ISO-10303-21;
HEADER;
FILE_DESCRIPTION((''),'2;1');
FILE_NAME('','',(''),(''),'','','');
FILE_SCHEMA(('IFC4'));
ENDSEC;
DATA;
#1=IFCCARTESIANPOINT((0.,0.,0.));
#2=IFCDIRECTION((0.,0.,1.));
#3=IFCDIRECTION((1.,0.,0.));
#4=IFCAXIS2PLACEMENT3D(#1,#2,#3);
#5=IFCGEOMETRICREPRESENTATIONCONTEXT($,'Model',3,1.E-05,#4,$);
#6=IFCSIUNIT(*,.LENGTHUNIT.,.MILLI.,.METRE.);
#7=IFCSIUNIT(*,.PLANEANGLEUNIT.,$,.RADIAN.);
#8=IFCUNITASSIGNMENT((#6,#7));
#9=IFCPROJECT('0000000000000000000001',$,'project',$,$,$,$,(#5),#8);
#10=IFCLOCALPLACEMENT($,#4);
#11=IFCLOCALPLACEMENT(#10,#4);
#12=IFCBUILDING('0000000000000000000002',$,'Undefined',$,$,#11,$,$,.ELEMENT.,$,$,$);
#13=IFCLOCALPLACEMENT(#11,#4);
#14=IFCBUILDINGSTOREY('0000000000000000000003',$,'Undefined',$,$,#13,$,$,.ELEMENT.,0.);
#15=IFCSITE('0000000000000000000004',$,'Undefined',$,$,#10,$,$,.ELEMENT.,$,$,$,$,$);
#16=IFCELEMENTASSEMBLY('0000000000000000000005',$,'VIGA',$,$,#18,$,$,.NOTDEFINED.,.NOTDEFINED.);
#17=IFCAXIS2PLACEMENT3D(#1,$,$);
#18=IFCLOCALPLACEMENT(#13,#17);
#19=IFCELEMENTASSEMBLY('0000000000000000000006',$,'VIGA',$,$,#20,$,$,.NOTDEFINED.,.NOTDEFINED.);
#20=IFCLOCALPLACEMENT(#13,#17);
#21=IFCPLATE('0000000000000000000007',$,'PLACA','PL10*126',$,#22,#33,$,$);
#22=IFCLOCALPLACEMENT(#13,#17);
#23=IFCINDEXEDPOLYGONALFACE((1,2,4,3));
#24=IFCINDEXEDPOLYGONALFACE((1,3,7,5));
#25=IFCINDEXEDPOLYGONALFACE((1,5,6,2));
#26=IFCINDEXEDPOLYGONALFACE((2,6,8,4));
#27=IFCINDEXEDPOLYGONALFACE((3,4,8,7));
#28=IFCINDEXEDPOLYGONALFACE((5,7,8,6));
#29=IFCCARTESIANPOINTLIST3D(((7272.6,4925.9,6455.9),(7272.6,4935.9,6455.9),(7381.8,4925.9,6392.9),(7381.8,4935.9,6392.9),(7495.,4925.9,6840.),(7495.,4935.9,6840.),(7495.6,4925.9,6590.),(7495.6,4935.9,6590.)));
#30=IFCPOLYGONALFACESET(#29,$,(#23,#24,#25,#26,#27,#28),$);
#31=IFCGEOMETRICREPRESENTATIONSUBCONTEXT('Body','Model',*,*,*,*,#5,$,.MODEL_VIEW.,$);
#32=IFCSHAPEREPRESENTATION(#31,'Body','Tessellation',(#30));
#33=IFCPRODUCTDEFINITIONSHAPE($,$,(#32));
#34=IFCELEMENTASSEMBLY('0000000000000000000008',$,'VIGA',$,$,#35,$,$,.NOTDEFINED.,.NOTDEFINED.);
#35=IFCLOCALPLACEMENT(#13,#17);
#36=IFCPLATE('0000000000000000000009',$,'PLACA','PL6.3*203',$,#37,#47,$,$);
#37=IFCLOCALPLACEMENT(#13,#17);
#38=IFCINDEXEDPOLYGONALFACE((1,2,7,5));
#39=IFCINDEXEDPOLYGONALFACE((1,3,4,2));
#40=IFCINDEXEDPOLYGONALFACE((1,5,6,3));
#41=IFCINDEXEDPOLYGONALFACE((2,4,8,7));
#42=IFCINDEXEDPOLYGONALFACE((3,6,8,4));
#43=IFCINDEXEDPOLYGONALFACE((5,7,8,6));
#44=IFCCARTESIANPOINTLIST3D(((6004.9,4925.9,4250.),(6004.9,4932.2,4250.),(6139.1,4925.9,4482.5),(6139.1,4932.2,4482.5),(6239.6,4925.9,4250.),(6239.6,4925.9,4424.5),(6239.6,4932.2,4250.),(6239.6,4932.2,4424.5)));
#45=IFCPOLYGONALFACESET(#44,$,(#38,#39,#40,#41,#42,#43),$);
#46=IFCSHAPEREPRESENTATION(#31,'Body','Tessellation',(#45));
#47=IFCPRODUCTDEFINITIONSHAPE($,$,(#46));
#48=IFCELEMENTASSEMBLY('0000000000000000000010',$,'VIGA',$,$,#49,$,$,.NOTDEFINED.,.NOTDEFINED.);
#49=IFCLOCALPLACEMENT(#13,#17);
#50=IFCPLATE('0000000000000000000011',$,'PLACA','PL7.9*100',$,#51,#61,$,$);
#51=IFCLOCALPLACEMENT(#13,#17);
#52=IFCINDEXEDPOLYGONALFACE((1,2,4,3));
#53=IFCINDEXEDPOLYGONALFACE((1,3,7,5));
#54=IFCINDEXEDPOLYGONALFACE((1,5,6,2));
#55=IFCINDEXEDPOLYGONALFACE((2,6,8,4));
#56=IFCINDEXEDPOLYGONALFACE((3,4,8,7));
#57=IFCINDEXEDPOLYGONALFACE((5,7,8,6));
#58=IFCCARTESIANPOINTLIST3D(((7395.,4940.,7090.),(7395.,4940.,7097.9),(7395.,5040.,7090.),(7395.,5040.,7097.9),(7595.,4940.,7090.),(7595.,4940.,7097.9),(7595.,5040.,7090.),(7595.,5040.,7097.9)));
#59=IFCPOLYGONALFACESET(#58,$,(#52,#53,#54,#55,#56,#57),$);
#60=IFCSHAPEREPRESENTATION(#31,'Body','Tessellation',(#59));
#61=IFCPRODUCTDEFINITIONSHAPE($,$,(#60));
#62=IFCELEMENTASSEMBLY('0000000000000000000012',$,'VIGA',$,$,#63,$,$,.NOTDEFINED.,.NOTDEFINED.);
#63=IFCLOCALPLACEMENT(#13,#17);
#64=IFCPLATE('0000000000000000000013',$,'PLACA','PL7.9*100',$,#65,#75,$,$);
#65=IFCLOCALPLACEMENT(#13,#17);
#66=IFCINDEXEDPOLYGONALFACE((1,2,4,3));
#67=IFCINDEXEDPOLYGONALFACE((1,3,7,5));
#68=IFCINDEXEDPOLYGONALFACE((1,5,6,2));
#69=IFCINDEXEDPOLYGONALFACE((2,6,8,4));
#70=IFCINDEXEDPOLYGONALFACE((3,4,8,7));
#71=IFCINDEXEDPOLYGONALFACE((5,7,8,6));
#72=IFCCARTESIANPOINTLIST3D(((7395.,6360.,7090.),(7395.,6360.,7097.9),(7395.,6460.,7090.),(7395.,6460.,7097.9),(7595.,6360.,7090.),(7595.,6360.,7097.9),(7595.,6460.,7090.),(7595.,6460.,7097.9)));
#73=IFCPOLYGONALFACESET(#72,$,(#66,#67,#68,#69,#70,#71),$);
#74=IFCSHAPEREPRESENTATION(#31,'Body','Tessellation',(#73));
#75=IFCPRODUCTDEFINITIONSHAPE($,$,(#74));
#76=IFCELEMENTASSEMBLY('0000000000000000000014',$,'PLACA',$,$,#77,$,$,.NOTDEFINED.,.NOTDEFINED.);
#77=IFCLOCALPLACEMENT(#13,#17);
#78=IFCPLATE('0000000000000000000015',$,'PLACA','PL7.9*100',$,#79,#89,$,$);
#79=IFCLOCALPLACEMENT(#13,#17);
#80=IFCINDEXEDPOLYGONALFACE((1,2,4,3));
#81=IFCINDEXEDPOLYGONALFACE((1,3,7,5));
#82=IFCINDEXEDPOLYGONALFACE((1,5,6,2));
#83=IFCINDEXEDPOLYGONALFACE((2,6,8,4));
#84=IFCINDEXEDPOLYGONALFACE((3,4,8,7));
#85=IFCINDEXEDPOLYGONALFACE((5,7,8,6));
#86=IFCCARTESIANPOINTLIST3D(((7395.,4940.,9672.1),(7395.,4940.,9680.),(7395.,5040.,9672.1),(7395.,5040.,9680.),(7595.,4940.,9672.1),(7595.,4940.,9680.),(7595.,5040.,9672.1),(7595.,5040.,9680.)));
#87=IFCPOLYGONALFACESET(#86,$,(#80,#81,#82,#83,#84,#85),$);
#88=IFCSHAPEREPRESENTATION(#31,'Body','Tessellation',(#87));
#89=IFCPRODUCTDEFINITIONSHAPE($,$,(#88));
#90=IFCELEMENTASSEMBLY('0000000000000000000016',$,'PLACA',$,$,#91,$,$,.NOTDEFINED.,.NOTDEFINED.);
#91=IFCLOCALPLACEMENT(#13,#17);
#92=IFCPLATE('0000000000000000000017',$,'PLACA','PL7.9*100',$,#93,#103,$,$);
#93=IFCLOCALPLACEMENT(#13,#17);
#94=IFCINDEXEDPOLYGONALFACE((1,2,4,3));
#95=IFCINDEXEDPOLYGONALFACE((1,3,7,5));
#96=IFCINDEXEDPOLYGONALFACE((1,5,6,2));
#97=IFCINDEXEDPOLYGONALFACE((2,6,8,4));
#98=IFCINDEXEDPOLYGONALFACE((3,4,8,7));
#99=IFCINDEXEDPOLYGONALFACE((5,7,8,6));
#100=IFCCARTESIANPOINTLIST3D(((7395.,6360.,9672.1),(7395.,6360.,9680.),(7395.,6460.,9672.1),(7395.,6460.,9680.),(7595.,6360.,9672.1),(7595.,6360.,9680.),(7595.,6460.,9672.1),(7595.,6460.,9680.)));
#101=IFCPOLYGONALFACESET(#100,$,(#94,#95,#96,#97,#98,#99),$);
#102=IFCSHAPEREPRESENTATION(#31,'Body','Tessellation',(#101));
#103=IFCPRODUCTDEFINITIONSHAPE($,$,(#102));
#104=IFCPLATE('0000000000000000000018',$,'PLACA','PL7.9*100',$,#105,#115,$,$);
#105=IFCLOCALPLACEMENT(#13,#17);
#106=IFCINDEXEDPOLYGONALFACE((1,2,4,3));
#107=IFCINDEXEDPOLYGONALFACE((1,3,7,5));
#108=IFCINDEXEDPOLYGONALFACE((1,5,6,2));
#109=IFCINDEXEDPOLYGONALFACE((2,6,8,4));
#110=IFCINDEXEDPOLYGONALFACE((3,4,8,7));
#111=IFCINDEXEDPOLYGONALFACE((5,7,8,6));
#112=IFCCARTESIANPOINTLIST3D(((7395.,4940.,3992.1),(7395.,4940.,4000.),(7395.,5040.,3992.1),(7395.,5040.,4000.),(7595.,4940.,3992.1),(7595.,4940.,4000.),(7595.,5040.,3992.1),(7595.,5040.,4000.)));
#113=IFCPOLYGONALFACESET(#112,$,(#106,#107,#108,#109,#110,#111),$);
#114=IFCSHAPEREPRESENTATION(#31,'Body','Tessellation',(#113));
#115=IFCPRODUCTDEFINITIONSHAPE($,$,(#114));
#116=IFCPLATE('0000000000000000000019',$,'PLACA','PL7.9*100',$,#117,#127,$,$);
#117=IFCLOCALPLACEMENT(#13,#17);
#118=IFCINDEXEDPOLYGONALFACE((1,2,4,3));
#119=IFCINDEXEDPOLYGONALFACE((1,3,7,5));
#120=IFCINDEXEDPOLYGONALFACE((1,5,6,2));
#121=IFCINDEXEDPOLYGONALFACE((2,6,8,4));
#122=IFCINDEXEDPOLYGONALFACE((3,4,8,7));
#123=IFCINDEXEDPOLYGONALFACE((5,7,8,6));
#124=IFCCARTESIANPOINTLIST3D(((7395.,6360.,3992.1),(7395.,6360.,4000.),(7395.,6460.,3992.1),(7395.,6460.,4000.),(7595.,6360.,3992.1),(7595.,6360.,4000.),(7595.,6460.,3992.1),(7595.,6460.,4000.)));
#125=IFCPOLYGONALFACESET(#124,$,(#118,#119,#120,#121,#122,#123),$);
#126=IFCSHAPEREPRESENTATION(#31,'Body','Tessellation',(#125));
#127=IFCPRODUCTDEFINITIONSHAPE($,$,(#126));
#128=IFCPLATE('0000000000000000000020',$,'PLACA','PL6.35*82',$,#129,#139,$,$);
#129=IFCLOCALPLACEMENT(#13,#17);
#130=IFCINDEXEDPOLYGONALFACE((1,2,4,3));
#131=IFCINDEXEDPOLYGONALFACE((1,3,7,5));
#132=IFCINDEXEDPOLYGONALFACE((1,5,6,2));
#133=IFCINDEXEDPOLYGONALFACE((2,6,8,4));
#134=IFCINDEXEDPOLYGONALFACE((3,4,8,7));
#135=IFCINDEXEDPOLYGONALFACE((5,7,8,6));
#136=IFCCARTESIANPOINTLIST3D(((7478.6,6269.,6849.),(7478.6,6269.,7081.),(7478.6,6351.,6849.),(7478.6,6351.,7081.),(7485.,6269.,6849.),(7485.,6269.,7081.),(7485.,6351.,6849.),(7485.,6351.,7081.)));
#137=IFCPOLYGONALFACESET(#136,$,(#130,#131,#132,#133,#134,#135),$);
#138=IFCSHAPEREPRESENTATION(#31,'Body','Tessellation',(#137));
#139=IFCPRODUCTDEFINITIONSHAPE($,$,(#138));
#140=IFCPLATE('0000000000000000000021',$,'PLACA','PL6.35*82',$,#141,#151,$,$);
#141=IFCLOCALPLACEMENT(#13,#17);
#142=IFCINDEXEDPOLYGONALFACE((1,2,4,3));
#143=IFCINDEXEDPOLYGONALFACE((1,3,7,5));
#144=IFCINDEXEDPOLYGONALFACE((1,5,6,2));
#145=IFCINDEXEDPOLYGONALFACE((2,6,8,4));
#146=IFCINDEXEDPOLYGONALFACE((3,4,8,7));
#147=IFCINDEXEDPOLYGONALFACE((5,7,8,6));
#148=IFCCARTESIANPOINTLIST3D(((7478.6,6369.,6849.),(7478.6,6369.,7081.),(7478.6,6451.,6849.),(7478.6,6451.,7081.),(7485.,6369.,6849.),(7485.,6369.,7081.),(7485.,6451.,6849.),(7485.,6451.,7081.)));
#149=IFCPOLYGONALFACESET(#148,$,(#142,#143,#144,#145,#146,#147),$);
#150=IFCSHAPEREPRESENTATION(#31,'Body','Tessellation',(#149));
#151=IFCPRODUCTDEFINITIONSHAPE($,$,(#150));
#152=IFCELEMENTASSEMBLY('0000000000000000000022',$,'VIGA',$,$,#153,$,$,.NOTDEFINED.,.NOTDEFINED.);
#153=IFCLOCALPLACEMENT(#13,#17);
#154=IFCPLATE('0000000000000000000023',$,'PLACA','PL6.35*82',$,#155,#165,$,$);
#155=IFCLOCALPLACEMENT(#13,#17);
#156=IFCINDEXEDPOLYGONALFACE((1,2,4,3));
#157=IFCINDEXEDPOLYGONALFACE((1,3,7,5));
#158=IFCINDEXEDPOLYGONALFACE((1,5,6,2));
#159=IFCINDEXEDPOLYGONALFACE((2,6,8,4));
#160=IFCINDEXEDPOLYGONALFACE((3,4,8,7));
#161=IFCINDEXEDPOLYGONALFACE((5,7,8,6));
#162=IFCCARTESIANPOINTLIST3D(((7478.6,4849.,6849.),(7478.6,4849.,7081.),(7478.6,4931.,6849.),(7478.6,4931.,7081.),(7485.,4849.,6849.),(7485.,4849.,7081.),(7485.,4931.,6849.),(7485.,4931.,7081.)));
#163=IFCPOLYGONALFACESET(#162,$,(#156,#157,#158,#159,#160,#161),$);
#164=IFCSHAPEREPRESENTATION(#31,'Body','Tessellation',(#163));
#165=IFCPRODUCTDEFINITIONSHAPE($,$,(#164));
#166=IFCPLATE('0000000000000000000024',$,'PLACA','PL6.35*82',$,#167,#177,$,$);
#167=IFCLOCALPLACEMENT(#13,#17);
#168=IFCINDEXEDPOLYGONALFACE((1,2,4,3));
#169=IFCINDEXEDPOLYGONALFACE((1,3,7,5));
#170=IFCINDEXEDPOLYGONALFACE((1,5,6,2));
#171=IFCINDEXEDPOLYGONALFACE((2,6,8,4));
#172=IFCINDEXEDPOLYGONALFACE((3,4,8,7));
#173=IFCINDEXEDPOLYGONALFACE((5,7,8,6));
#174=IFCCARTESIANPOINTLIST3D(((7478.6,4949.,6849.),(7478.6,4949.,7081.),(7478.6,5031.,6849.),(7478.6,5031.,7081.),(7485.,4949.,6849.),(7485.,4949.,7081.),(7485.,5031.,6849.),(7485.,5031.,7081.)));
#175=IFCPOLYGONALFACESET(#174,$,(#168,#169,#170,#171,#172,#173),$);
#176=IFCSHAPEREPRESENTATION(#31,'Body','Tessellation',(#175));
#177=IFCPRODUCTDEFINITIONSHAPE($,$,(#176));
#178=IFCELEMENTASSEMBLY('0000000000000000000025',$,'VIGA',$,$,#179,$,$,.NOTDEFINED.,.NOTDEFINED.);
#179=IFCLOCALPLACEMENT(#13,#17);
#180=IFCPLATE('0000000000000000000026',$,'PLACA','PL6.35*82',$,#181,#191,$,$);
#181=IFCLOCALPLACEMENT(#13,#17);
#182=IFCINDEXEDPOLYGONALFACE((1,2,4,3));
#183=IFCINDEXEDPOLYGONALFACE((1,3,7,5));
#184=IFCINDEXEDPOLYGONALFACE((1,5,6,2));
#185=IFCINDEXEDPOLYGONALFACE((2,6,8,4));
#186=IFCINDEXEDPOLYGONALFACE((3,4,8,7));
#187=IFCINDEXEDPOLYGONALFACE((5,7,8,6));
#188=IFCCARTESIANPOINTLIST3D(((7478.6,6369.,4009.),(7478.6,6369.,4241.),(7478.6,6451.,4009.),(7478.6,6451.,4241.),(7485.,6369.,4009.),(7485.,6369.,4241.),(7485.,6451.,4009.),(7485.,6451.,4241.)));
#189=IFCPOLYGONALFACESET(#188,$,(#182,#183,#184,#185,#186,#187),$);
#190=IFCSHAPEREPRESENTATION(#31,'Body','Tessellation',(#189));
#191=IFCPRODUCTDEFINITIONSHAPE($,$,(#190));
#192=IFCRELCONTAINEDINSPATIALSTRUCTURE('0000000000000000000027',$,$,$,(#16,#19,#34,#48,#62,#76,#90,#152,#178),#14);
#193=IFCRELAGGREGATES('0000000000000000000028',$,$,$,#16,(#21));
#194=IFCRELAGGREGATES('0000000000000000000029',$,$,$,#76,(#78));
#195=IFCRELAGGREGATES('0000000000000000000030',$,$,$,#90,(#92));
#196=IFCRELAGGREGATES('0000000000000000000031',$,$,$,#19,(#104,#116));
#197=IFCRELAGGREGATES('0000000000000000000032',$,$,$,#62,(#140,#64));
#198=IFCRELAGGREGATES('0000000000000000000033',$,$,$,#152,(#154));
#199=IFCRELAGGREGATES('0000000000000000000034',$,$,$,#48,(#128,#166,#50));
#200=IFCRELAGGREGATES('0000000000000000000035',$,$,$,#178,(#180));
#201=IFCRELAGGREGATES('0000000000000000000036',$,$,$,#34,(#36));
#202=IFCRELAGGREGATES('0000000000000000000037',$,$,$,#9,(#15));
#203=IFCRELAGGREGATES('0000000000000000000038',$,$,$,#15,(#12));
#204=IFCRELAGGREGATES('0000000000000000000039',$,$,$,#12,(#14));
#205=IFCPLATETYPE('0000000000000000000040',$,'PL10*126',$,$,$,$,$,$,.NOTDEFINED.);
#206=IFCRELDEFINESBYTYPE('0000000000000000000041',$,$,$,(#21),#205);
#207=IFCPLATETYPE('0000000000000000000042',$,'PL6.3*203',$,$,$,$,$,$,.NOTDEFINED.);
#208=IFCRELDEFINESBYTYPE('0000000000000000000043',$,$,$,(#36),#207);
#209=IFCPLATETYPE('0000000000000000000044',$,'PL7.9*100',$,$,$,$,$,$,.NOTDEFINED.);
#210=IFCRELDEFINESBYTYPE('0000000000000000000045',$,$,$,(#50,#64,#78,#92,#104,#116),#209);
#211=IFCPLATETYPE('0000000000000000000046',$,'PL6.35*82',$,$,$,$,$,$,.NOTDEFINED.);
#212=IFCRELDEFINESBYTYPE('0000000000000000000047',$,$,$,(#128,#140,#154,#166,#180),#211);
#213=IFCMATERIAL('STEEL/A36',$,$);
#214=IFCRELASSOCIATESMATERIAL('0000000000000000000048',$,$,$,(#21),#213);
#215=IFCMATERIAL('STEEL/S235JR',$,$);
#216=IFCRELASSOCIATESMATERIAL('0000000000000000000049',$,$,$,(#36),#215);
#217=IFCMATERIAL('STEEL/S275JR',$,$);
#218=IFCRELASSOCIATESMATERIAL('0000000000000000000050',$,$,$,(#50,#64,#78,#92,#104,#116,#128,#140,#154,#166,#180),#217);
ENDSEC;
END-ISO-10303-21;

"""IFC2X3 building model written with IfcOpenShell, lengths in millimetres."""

from ifc_helpers import new_model, si_unit, frame, origin_with_axes, place, context, subcontext, project, spatial, polyline, outline, extrude, material, type_object, element, aggregate, save


model = new_model("IFC2X3")

# Units and contexts
model_context = context("Model", 3, precision=1e-05, world=origin_with_axes())
body_context = subcontext(model_context, "Body", "Model", "MODEL_VIEW")
ifc_project = project(units=[si_unit("LENGTHUNIT", "METRE", prefix="MILLI"), si_unit("PLANEANGLEUNIT", "RADIAN")], contexts=[model_context])

# Site, building, storey
site_placement = place(None, origin_with_axes())
site = spatial("IfcSite", under=ifc_project, at=site_placement, Name="Undefined", CompositionType="ELEMENT")
building_placement = place(site_placement, origin_with_axes())
building = spatial("IfcBuilding", under=site, at=building_placement, Name="Undefined", CompositionType="ELEMENT")
storey_placement = place(building_placement, origin_with_axes())
storey = spatial("IfcBuildingStorey", under=building, at=storey_placement, Name="Undefined", CompositionType="ELEMENT", Elevation=0.0)

# Element assemblies
ifc_material_1 = material(Name="STEEL/S275JR")
assembly_1_placement = place(storey_placement, origin_with_axes())
assembly_1 = element("IfcElementAssembly", 1, at=assembly_1_placement, inside=storey, Name="VIGA", AssemblyPlace="NOTDEFINED", PredefinedType="NOTDEFINED")
assembly_2_placement = place(storey_placement, origin_with_axes())
assembly_2 = element("IfcElementAssembly", 2, at=assembly_2_placement, inside=storey, Name="VIGA", AssemblyPlace="NOTDEFINED", PredefinedType="NOTDEFINED")

# Shared definitions
ifc_material_2 = material(Name="STEEL/S235JR")

# Plate
ifc_material_3 = material(Name="STEEL/A36")
plate_type_1 = type_object("IfcPlateType", Name="PL10*126", PredefinedType="NOTDEFINED")
plate_1_placement = place(assembly_1_placement, frame((7495.0, 4930.9, 6840.0), z_axis=(0.0, -1.0, 0.0), x_axis=(-0.500975, 0.0, -0.865462)))
plate_1 = element("IfcPlate", 3, at=plate_1_placement, type_object=plate_type_1, material=ifc_material_3, Name="PLACA", Description="PL10*126", context=body_context, shape_type="SweptSolid", body=[
    extrude(outline(polyline([(0.0, 0.0), (443.9, 0.0), (443.7, 126.0), (216.1, 125.7), (0.0, 0.0)])), frame((0.0, 0.0, -5.0), z_axis=(0.0, 0.0, 1.0), x_axis=(1.0, 0.0, 0.0)), (0.0, 0.0, 1.0), 10.0),
])
aggregate(assembly_1, [plate_1])

# Element assemblies, plates
assembly_3_placement = place(storey_placement, origin_with_axes())
assembly_3 = element("IfcElementAssembly", 4, at=assembly_3_placement, inside=storey, Name="VIGA", AssemblyPlace="NOTDEFINED", PredefinedType="NOTDEFINED")
plate_type_2 = type_object("IfcPlateType", Name="PL6.3*203", PredefinedType="NOTDEFINED")
plate_2_placement = place(assembly_3_placement, frame((6239.6, 4929.0, 4250.0), z_axis=(0.0, 1.0, 0.0), x_axis=(-1.0, 0.0, 0.0)))
plate_2 = element("IfcPlate", 5, at=plate_2_placement, type_object=plate_type_2, material=ifc_material_2, Name="PLACA", Description="PL6.3*203", context=body_context, shape_type="SweptSolid", body=[
    extrude(outline(polyline([(0.0, 0.0), (234.7, 0.0), (100.5, 232.5), (0.0, 174.5), (0.0, 0.0)])), frame((0.0, 0.0, -3.1), z_axis=(0.0, 0.0, 1.0), x_axis=(1.0, 0.0, 0.0)), (0.0, 0.0, 1.0), 6.3),
])
assembly_4_placement = place(storey_placement, origin_with_axes())
assembly_4 = element("IfcElementAssembly", 6, at=assembly_4_placement, inside=storey, Name="VIGA", AssemblyPlace="NOTDEFINED", PredefinedType="NOTDEFINED")
plate_type_3 = type_object("IfcPlateType", Name="PL7.9*100", PredefinedType="NOTDEFINED")
plate_3_placement = place(assembly_4_placement, frame((7395.0, 5040.0, 7093.9), z_axis=(0.0, 0.0, 1.0), x_axis=(0.0, -1.0, 0.0)))
plate_3 = element("IfcPlate", 7, at=plate_3_placement, type_object=plate_type_3, material=ifc_material_1, Name="PLACA", Description="PL7.9*100", context=body_context, shape_type="SweptSolid", body=[
    extrude(outline(polyline([(0.0, 0.0), (100.0, 0.0), (100.0, 200.0), (0.0, 200.0), (0.0, 0.0)])), frame((0.0, 0.0, -4.0), z_axis=(0.0, 0.0, 1.0), x_axis=(1.0, 0.0, 0.0)), (0.0, 0.0, 1.0), 7.9),
])
assembly_5_placement = place(storey_placement, origin_with_axes())
assembly_5 = element("IfcElementAssembly", 8, at=assembly_5_placement, inside=storey, Name="VIGA", AssemblyPlace="NOTDEFINED", PredefinedType="NOTDEFINED")
plate_4_placement = place(assembly_5_placement, frame((7395.0, 6460.0, 7093.9), z_axis=(0.0, 0.0, 1.0), x_axis=(0.0, -1.0, 0.0)))
plate_4 = element("IfcPlate", 9, at=plate_4_placement, type_object=plate_type_3, material=ifc_material_1, Name="PLACA", Description="PL7.9*100", context=body_context, shape_type="SweptSolid", body=[
    extrude(outline(polyline([(0.0, 0.0), (100.0, 0.0), (100.0, 200.0), (0.0, 200.0), (0.0, 0.0)])), frame((0.0, 0.0, -4.0), z_axis=(0.0, 0.0, 1.0), x_axis=(1.0, 0.0, 0.0)), (0.0, 0.0, 1.0), 7.9),
])
assembly_6_placement = place(storey_placement, origin_with_axes())
assembly_6 = element("IfcElementAssembly", 10, at=assembly_6_placement, inside=storey, Name="PLACA", AssemblyPlace="NOTDEFINED", PredefinedType="NOTDEFINED")
plate_5_placement = place(assembly_6_placement, frame((7395.0, 5040.0, 9676.0), z_axis=(0.0, 0.0, 1.0), x_axis=(0.0, -1.0, 0.0)))
plate_5 = element("IfcPlate", 11, at=plate_5_placement, type_object=plate_type_3, material=ifc_material_1, Name="PLACA", Description="PL7.9*100", context=body_context, shape_type="SweptSolid", body=[
    extrude(outline(polyline([(0.0, 0.0), (100.0, 0.0), (100.0, 200.0), (0.0, 200.0), (0.0, 0.0)])), frame((0.0, 0.0, -4.0), z_axis=(0.0, 0.0, 1.0), x_axis=(1.0, 0.0, 0.0)), (0.0, 0.0, 1.0), 7.9),
])
aggregate(assembly_6, [plate_5])
assembly_7_placement = place(storey_placement, origin_with_axes())
assembly_7 = element("IfcElementAssembly", 12, at=assembly_7_placement, inside=storey, Name="PLACA", AssemblyPlace="NOTDEFINED", PredefinedType="NOTDEFINED")
plate_6_placement = place(assembly_7_placement, frame((7395.0, 6460.0, 9676.0), z_axis=(0.0, 0.0, 1.0), x_axis=(0.0, -1.0, 0.0)))
plate_6 = element("IfcPlate", 13, at=plate_6_placement, type_object=plate_type_3, material=ifc_material_1, Name="PLACA", Description="PL7.9*100", context=body_context, shape_type="SweptSolid", body=[
    extrude(outline(polyline([(0.0, 0.0), (100.0, 0.0), (100.0, 200.0), (0.0, 200.0), (0.0, 0.0)])), frame((0.0, 0.0, -4.0), z_axis=(0.0, 0.0, 1.0), x_axis=(1.0, 0.0, 0.0)), (0.0, 0.0, 1.0), 7.9),
])
aggregate(assembly_7, [plate_6])

# Plates
plate_7_placement = place(assembly_2_placement, frame((7395.0, 5040.0, 3996.1), z_axis=(0.0, 0.0, 1.0), x_axis=(0.0, -1.0, 0.0)))
plate_7 = element("IfcPlate", 14, at=plate_7_placement, type_object=plate_type_3, material=ifc_material_1, Name="PLACA", Description="PL7.9*100", context=body_context, shape_type="SweptSolid", body=[
    extrude(outline(polyline([(0.0, 0.0), (100.0, 0.0), (100.0, 200.0), (0.0, 200.0), (0.0, 0.0)])), frame((0.0, 0.0, -4.0), z_axis=(0.0, 0.0, 1.0), x_axis=(1.0, 0.0, 0.0)), (0.0, 0.0, 1.0), 7.9),
])
plate_8_placement = place(assembly_2_placement, frame((7395.0, 6460.0, 3996.1), z_axis=(0.0, 0.0, 1.0), x_axis=(0.0, -1.0, 0.0)))
plate_8 = element("IfcPlate", 15, at=plate_8_placement, type_object=plate_type_3, material=ifc_material_1, Name="PLACA", Description="PL7.9*100", context=body_context, shape_type="SweptSolid", body=[
    extrude(outline(polyline([(0.0, 0.0), (100.0, 0.0), (100.0, 200.0), (0.0, 200.0), (0.0, 0.0)])), frame((0.0, 0.0, -4.0), z_axis=(0.0, 0.0, 1.0), x_axis=(1.0, 0.0, 0.0)), (0.0, 0.0, 1.0), 7.9),
])
aggregate(assembly_2, [plate_7, plate_8])
plate_type_4 = type_object("IfcPlateType", Name="PL6.35*82", PredefinedType="NOTDEFINED")
plate_9_placement = place(assembly_4_placement, frame((7481.8, 6269.0, 7081.0), z_axis=(-1.0, 0.0, 0.0), x_axis=(0.0, 1.0, 0.0)))
plate_9 = element("IfcPlate", 16, at=plate_9_placement, type_object=plate_type_4, material=ifc_material_1, Name="PLACA", Description="PL6.35*82", context=body_context, shape_type="SweptSolid", body=[
    extrude(outline(polyline([(0.0, 0.0), (82.0, 0.0), (82.0, 232.0), (0.0, 232.0), (0.0, 0.0)])), frame((0.0, 0.0, -3.2), z_axis=(0.0, 0.0, 1.0), x_axis=(1.0, 0.0, 0.0)), (0.0, 0.0, 1.0), 6.4),
])
plate_10_placement = place(assembly_5_placement, frame((7481.8, 6369.0, 7081.0), z_axis=(-1.0, 0.0, 0.0), x_axis=(0.0, 1.0, 0.0)))
plate_10 = element("IfcPlate", 17, at=plate_10_placement, type_object=plate_type_4, material=ifc_material_1, Name="PLACA", Description="PL6.35*82", context=body_context, shape_type="SweptSolid", body=[
    extrude(outline(polyline([(0.0, 0.0), (82.0, 0.0), (82.0, 232.0), (0.0, 232.0), (0.0, 0.0)])), frame((0.0, 0.0, -3.2), z_axis=(0.0, 0.0, 1.0), x_axis=(1.0, 0.0, 0.0)), (0.0, 0.0, 1.0), 6.4),
])
aggregate(assembly_5, [plate_10, plate_4])

# Element assembly, plate
assembly_8_placement = place(storey_placement, origin_with_axes())
assembly_8 = element("IfcElementAssembly", 18, at=assembly_8_placement, inside=storey, Name="VIGA", AssemblyPlace="NOTDEFINED", PredefinedType="NOTDEFINED")
plate_11_placement = place(assembly_8_placement, frame((7481.8, 4849.0, 7081.0), z_axis=(-1.0, 0.0, 0.0), x_axis=(0.0, 1.0, 0.0)))
plate_11 = element("IfcPlate", 19, at=plate_11_placement, type_object=plate_type_4, material=ifc_material_1, Name="PLACA", Description="PL6.35*82", context=body_context, shape_type="SweptSolid", body=[
    extrude(outline(polyline([(0.0, 0.0), (82.0, 0.0), (82.0, 232.0), (0.0, 232.0), (0.0, 0.0)])), frame((0.0, 0.0, -3.2), z_axis=(0.0, 0.0, 1.0), x_axis=(1.0, 0.0, 0.0)), (0.0, 0.0, 1.0), 6.4),
])
aggregate(assembly_8, [plate_11])

# Plate
plate_12_placement = place(assembly_4_placement, frame((7481.8, 4949.0, 7081.0), z_axis=(-1.0, 0.0, 0.0), x_axis=(0.0, 1.0, 0.0)))
plate_12 = element("IfcPlate", 20, at=plate_12_placement, type_object=plate_type_4, material=ifc_material_1, Name="PLACA", Description="PL6.35*82", context=body_context, shape_type="SweptSolid", body=[
    extrude(outline(polyline([(0.0, 0.0), (82.0, 0.0), (82.0, 232.0), (0.0, 232.0), (0.0, 0.0)])), frame((0.0, 0.0, -3.2), z_axis=(0.0, 0.0, 1.0), x_axis=(1.0, 0.0, 0.0)), (0.0, 0.0, 1.0), 6.4),
])
aggregate(assembly_4, [plate_9, plate_12, plate_3])

# Element assembly, plate
assembly_9_placement = place(storey_placement, origin_with_axes())
assembly_9 = element("IfcElementAssembly", 21, at=assembly_9_placement, inside=storey, Name="VIGA", AssemblyPlace="NOTDEFINED", PredefinedType="NOTDEFINED")
plate_13_placement = place(assembly_9_placement, frame((7481.8, 6369.0, 4241.0), z_axis=(-1.0, 0.0, 0.0), x_axis=(0.0, 1.0, 0.0)))
plate_13 = element("IfcPlate", 22, at=plate_13_placement, type_object=plate_type_4, material=ifc_material_1, Name="PLACA", Description="PL6.35*82", context=body_context, shape_type="SweptSolid", body=[
    extrude(outline(polyline([(0.0, 0.0), (82.0, 0.0), (82.0, 232.0), (0.0, 232.0), (0.0, 0.0)])), frame((0.0, 0.0, -3.2), z_axis=(0.0, 0.0, 1.0), x_axis=(1.0, 0.0, 0.0)), (0.0, 0.0, 1.0), 6.4),
])
aggregate(assembly_9, [plate_13])

aggregate(assembly_3, [plate_2])

save(model, "model.ifc")
